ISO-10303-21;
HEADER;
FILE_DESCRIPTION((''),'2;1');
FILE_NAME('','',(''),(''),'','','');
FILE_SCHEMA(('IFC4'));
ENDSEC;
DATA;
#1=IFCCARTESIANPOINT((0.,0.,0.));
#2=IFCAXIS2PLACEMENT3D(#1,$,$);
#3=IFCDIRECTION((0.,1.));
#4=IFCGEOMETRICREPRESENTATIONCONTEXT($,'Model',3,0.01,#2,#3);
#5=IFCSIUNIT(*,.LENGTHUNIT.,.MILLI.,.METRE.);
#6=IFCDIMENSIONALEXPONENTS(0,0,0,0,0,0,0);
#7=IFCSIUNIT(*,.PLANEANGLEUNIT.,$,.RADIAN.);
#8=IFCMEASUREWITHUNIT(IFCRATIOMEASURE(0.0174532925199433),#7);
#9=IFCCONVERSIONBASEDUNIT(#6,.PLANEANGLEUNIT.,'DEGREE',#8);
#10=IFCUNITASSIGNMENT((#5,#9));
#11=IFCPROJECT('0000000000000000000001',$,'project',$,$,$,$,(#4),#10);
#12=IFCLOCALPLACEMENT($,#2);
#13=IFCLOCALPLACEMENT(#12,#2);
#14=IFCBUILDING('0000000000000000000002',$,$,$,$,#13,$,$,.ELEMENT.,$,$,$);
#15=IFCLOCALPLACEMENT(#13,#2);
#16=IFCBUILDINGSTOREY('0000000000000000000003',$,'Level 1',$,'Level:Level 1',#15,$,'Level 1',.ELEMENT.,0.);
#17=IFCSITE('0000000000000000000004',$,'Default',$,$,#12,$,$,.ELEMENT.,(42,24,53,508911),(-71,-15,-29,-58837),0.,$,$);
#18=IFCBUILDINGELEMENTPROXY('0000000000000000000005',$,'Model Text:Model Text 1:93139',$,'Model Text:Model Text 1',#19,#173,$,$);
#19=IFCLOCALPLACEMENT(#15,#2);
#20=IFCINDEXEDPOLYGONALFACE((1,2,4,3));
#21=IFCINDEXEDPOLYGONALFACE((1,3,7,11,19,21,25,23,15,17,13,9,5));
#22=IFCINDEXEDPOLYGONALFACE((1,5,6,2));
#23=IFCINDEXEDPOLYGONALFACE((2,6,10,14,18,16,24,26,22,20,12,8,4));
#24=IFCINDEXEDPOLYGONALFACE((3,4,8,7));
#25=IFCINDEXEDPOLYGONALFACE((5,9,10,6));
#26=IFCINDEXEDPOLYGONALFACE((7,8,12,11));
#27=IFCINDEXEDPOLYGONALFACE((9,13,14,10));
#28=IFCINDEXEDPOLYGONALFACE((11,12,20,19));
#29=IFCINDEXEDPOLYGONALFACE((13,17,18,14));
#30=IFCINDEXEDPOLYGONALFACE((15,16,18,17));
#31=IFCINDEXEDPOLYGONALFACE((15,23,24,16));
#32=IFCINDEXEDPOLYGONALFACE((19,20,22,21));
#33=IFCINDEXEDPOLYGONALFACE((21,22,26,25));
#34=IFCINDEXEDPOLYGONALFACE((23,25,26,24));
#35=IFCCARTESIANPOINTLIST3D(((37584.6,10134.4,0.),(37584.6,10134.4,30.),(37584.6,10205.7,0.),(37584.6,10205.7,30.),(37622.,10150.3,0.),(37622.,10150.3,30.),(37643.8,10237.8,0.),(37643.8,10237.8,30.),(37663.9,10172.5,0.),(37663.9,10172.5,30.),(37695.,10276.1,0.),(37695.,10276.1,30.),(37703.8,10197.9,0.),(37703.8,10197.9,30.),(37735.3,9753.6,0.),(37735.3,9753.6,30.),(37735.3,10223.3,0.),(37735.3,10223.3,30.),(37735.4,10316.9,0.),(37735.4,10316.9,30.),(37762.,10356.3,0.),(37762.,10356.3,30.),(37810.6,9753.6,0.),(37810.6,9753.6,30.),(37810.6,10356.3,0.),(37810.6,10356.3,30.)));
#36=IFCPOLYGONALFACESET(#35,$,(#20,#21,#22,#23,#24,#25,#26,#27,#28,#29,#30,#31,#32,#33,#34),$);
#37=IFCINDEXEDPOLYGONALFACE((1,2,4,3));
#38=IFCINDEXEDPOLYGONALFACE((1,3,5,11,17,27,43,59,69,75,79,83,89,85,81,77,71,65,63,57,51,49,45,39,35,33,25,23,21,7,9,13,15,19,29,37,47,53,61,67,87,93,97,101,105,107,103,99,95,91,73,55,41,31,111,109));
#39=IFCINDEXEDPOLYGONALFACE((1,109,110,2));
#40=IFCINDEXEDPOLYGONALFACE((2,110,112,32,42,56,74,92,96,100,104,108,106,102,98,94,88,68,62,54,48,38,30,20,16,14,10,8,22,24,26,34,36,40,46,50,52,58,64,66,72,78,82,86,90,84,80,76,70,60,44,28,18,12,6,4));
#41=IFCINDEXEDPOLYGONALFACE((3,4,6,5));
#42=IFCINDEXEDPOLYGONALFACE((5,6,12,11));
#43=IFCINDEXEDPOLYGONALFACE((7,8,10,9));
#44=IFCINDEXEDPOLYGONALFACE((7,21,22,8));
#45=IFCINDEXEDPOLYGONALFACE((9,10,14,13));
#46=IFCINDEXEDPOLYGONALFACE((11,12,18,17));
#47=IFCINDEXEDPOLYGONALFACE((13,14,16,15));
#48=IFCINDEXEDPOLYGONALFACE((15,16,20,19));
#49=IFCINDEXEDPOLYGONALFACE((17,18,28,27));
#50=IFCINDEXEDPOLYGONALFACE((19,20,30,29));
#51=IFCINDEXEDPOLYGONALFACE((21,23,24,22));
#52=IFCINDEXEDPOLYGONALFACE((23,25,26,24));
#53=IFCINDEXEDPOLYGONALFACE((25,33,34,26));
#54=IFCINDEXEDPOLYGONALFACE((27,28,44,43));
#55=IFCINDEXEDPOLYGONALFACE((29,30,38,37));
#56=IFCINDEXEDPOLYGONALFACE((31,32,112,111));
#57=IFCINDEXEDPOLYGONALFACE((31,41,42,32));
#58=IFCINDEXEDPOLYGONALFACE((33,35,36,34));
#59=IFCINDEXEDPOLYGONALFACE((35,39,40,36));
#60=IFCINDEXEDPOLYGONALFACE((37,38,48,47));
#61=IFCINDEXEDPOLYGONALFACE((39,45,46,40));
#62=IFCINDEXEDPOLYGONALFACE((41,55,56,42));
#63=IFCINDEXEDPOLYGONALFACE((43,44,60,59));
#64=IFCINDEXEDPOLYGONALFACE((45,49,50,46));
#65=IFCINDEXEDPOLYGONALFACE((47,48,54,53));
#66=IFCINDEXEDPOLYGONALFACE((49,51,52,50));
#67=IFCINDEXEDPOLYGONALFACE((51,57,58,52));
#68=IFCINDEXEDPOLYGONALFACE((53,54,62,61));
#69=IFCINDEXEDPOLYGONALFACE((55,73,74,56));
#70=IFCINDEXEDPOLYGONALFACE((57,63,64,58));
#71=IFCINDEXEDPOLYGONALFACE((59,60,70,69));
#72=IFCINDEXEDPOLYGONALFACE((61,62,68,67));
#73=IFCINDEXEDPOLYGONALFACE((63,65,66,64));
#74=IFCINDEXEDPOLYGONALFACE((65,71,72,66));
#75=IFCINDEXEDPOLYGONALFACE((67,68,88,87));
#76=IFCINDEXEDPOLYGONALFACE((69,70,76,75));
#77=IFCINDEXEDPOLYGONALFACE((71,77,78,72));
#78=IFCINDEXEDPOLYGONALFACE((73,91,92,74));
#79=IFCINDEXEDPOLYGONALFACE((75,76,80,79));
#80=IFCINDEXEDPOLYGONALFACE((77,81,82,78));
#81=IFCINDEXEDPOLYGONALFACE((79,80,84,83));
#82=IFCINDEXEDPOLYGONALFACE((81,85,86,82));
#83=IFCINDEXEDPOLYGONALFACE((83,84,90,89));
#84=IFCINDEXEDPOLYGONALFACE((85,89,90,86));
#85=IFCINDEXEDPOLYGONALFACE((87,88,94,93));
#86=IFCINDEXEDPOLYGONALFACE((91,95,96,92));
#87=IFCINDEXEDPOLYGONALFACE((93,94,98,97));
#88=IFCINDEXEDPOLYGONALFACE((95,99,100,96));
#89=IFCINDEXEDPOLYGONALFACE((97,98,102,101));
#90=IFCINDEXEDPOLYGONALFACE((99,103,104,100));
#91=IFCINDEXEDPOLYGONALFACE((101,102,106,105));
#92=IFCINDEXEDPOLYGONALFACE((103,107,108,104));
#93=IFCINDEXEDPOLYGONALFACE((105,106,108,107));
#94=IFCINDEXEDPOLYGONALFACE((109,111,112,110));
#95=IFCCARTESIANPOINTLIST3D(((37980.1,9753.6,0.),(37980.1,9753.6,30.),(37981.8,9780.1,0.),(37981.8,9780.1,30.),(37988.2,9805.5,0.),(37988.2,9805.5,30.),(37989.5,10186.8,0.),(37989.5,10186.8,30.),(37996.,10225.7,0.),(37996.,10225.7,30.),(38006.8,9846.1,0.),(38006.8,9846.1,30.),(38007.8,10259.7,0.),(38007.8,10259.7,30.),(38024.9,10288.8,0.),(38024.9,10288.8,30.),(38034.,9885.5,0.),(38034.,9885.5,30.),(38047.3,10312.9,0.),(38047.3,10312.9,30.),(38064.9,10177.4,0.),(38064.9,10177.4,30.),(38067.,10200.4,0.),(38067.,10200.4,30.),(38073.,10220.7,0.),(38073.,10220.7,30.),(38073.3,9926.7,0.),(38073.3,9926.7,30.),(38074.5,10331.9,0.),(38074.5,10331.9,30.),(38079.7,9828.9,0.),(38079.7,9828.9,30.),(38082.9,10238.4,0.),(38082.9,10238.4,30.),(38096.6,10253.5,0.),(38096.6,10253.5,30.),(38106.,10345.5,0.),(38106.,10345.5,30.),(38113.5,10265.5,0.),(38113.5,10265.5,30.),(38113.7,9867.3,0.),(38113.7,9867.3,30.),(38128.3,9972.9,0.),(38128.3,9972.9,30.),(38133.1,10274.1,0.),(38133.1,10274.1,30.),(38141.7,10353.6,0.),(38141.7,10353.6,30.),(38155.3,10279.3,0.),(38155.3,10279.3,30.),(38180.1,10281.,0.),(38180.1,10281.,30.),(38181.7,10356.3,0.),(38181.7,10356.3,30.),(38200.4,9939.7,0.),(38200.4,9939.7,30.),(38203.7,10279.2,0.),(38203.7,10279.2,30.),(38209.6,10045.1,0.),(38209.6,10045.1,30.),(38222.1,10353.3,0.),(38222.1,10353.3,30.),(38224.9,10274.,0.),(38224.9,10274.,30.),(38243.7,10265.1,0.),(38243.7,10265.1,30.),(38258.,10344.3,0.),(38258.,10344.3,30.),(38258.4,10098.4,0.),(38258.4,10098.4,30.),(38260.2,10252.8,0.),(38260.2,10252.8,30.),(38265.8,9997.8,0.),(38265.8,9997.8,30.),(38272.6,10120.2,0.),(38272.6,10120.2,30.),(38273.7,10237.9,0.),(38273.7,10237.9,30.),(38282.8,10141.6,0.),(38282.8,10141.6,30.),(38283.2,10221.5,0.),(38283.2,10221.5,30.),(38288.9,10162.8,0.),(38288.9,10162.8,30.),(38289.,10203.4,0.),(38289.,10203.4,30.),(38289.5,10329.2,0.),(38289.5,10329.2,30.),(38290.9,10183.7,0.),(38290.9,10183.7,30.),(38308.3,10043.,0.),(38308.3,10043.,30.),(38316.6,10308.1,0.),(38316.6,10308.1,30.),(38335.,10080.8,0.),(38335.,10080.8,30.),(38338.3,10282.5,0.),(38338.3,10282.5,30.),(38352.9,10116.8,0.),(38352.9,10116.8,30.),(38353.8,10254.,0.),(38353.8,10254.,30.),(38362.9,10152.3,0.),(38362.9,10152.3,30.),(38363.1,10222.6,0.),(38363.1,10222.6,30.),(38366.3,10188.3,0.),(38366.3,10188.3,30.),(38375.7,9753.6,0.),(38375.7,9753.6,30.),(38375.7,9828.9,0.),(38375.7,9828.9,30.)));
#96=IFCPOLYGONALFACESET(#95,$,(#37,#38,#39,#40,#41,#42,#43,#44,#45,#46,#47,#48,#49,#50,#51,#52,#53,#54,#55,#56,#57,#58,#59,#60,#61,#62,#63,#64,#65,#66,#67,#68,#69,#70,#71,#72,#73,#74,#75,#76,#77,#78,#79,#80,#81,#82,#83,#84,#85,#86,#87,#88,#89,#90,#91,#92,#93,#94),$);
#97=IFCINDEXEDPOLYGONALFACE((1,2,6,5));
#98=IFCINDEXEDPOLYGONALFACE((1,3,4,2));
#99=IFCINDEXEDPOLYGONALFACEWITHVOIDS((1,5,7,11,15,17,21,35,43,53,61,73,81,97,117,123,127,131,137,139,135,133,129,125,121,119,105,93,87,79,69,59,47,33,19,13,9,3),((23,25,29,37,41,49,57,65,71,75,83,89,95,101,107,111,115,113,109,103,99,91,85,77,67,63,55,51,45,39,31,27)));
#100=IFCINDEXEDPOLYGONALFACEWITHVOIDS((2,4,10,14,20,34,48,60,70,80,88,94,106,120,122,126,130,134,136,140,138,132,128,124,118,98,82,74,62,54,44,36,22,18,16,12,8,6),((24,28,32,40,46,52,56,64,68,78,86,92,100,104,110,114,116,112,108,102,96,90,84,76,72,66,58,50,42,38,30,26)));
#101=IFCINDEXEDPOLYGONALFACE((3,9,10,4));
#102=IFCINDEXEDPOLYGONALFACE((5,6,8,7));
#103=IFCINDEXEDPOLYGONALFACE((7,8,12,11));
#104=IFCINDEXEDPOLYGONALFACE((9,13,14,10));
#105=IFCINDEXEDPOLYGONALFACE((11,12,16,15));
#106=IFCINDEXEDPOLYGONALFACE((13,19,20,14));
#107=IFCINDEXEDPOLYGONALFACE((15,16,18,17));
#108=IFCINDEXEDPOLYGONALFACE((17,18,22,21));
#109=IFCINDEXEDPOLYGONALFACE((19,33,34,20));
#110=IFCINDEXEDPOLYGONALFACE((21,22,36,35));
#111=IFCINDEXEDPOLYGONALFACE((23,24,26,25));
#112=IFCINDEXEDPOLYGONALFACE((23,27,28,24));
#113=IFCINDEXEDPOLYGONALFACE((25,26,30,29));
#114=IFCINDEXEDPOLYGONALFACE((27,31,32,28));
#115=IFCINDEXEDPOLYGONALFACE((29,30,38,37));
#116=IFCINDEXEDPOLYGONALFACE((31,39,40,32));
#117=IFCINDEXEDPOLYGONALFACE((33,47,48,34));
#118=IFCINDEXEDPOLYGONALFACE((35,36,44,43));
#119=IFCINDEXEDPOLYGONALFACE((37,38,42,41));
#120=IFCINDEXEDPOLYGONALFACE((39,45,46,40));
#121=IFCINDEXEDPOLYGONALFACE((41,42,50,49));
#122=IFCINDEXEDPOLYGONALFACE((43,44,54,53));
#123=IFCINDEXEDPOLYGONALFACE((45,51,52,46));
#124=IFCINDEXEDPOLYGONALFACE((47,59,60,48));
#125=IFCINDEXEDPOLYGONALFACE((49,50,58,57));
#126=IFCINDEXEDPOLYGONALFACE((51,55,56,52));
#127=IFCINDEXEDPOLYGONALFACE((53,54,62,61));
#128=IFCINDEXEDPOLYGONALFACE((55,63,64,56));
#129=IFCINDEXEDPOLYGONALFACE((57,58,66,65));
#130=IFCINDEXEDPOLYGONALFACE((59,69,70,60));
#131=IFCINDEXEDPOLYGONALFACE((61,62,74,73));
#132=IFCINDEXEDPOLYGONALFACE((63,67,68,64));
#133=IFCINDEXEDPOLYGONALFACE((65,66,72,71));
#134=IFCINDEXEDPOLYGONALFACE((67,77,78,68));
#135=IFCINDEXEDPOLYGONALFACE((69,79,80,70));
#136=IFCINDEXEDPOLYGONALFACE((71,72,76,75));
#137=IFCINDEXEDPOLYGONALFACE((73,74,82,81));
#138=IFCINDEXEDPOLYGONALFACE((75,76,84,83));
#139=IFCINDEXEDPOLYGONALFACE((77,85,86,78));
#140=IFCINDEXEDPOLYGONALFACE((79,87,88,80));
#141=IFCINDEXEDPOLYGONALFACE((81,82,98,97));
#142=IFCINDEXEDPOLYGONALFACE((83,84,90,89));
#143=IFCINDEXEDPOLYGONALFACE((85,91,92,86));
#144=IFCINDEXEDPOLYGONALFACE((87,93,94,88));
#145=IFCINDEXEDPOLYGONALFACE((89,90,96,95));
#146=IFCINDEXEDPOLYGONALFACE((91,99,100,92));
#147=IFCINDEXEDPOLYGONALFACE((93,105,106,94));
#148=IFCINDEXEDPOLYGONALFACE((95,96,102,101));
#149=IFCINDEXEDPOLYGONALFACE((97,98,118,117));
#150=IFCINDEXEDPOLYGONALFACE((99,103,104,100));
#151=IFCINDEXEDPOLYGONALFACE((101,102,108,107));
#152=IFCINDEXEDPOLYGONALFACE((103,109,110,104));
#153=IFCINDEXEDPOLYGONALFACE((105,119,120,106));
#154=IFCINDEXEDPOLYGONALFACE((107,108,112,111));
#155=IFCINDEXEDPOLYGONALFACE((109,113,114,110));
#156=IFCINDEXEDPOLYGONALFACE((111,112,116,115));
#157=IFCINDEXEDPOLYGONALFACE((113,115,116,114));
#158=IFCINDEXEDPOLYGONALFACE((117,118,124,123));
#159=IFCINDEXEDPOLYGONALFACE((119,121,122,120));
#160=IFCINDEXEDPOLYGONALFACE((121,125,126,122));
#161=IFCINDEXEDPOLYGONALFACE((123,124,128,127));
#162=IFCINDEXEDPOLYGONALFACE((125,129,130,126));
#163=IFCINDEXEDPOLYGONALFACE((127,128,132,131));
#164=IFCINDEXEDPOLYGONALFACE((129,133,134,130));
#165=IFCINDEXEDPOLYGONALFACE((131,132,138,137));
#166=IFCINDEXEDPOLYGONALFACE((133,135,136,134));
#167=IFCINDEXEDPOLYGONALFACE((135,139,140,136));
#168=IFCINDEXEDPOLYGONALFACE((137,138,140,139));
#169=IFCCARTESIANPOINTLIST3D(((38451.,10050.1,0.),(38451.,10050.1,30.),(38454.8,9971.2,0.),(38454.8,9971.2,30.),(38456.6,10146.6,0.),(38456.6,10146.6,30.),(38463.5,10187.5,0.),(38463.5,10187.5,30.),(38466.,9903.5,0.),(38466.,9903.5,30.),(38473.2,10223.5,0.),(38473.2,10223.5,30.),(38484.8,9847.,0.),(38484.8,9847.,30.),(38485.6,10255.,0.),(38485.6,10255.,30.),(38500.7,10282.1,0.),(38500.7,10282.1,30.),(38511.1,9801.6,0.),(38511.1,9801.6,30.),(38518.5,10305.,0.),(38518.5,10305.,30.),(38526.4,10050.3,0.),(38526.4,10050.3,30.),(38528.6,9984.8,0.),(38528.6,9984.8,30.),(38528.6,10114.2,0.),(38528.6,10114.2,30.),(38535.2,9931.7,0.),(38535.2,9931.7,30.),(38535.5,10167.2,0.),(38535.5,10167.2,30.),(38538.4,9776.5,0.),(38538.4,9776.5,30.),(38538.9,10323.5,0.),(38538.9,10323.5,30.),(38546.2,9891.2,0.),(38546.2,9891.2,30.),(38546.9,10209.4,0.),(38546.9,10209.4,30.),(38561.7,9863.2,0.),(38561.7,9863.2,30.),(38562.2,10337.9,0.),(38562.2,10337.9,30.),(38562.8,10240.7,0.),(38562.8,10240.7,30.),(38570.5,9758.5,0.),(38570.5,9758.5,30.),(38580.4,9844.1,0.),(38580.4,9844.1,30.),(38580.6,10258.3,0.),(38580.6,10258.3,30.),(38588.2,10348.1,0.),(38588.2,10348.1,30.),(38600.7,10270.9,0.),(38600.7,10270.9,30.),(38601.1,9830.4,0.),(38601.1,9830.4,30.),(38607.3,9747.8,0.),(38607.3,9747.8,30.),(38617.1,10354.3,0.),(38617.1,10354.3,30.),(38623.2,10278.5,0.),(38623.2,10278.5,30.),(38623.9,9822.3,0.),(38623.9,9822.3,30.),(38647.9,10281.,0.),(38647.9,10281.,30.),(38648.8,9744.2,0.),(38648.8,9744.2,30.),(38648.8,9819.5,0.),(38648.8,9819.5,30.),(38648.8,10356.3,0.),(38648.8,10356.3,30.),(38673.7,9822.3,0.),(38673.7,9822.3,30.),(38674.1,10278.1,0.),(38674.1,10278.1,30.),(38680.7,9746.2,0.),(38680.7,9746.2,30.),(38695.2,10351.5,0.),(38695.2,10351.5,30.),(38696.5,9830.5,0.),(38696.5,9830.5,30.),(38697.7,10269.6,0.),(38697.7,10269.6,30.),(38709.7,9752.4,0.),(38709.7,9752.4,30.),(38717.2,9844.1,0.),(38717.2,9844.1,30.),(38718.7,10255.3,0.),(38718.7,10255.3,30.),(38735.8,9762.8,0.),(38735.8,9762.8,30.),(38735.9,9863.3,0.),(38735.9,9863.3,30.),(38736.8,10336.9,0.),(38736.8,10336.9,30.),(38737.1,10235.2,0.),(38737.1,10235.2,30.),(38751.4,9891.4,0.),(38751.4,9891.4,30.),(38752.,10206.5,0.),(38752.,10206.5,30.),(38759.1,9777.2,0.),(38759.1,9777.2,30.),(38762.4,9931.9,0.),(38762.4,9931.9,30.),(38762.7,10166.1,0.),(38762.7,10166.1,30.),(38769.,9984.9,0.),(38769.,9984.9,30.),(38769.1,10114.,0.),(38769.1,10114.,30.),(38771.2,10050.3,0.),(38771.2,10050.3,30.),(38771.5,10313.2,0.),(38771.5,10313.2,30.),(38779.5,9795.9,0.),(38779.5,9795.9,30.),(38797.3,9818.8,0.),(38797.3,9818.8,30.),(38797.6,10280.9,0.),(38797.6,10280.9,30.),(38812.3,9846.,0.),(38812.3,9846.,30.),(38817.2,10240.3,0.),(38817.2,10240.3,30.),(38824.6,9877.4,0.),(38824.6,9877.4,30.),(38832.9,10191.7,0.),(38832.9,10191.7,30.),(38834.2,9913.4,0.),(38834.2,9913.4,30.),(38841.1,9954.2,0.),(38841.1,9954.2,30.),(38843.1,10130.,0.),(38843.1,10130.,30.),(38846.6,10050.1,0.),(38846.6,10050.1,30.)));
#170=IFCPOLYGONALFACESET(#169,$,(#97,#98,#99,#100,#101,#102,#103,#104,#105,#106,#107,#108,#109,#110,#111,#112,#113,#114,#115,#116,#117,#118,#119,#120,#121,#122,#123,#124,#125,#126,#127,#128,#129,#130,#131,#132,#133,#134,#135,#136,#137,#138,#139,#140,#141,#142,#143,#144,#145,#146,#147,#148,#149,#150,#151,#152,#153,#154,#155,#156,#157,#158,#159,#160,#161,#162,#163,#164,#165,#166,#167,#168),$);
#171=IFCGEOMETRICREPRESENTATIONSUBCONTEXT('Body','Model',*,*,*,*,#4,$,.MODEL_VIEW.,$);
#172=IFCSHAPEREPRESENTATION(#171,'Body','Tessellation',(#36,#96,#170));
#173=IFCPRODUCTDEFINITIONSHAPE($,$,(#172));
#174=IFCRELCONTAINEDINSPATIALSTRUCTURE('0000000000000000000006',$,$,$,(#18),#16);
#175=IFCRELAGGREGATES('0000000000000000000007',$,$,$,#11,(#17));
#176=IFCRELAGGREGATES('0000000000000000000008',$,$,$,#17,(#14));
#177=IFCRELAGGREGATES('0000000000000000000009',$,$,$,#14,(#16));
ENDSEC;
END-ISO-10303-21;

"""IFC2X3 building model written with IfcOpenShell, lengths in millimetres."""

from ifc_helpers import new_model, entity, si_unit, converted_unit, direction, frame, origin, place, context, subcontext, project, spatial, polyline, outline, extrude, element, save


model = new_model("IFC2X3")

# Units and contexts
model_context = context("Model", 3, precision=0.01, world=origin(), true_north=direction((0.0, 1.0)))
body_context = subcontext(model_context, "Body", "Model", "MODEL_VIEW")
ifc_project = project(units=[si_unit("LENGTHUNIT", "METRE", prefix="MILLI"), converted_unit("PLANEANGLEUNIT", "DEGREE", entity("IfcRatioMeasure", 0.0174532925199433), si_unit("PLANEANGLEUNIT", "RADIAN"), dimensions=[0, 0, 0, 0, 0, 0, 0])], contexts=[model_context])

# Site, building, storey
site_placement = place(None, origin())
site = spatial("IfcSite", under=ifc_project, at=site_placement, Name="Default", CompositionType="ELEMENT", RefLatitude=(42, 24, 53, 508911), RefLongitude=(-71, -15, -29, -58837), RefElevation=0.0)
building_placement = place(site_placement, origin())
building = spatial("IfcBuilding", under=site, at=building_placement, CompositionType="ELEMENT")
storey_placement = place(building_placement, origin())
storey = spatial("IfcBuildingStorey", under=building, at=storey_placement, Name="Level 1", ObjectType="Level:Level 1", LongName="Level 1", CompositionType="ELEMENT", Elevation=0.0)

# Building element proxy
proxy_1_placement = place(storey_placement, origin())
element("IfcBuildingElementProxy", 1, at=proxy_1_placement, inside=storey, Name="Model Text:Model Text 1:93139", ObjectType="Model Text:Model Text 1", context=body_context, shape_type="SweptSolid", body=[
    extrude(outline(polyline([(-410.6, -111.6), (192.1, -111.6), (192.1, -63.1), (152.7, -36.4), (111.9, 4.0), (73.6, 55.2), (41.4, 114.4), (-29.8, 114.4), (-13.9, 77.0), (8.3, 35.1), (33.7, -4.8), (59.1, -36.3), (-410.6, -36.3), (-410.6, -111.6)])), frame((37699.0, 10164.2, 0.0), z_axis=(0.0, 0.0, 1.0), x_axis=(0.0, 1.0, 0.0)), (0.0, 0.0, 1.0), 30.0),
    extrude(outline(polyline([(-190.2, -317.5), (-190.2, -392.8), (205.4, -392.8), (203.7, -366.3), (197.3, -340.9), (178.7, -300.3), (151.5, -260.9), (112.2, -219.7), (57.2, -173.6), (-24.1, -101.3), (-72.9, -48.0), (-87.1, -26.3), (-97.3, -4.8), (-103.4, 16.4), (-105.4, 37.3), (-103.5, 57.0), (-97.7, 75.0), (-88.2, 91.5), (-74.7, 106.4), (-58.2, 118.7), (-39.4, 127.5), (-18.2, 132.8), (5.4, 134.6), (30.2, 132.9), (52.4, 127.7), (72.0, 119.1), (88.9, 107.1), (102.6, 92.0), (112.5, 74.3), (118.5, 54.0), (120.6, 31.0), (196.0, 40.4), (189.5, 79.3), (177.7, 113.3), (160.6, 142.4), (138.2, 166.5), (111.0, 185.5), (79.5, 199.1), (43.8, 207.2), (3.8, 209.9), (-36.6, 206.9), (-72.5, 197.9), (-104.0, 182.8), (-131.1, 161.7), (-152.8, 136.1), (-168.3, 107.6), (-177.6, 76.2), (-180.8, 41.9), (-177.4, 5.8), (-167.4, -29.6), (-149.5, -65.6), (-122.8, -103.4), (-80.3, -148.6), (-14.9, -206.7), (71.8, -279.1), (105.8, -317.5), (-190.2, -317.5)])), frame((38185.5, 10146.4, 0.0), z_axis=(0.0, 0.0, -1.0), x_axis=(-1.0, 0.0, 0.0)), (0.0, 0.0, -1.0), 30.0),
    extrude(outline(polyline([(-10.6, -198.7), (68.3, -198.7), (136.5, -190.7), (193.9, -174.7), (240.5, -150.6), (266.9, -124.4), (286.3, -93.2), (298.8, -57.0), (304.3, -15.7), (303.8, 16.2), (299.0, 45.5), (289.9, 72.1), (276.6, 96.0), (258.9, 117.3), (236.9, 136.2), (210.4, 152.5), (179.6, 166.3), (144.1, 177.6), (103.7, 186.3), (8.2, 196.4), (-71.8, 196.7), (-134.0, 189.4), (-183.3, 176.1), (-224.7, 158.4), (-258.2, 133.9), (-283.5, 100.3), (-300.1, 59.5), (-307.1, 13.4), (-306.6, -18.4), (-301.8, -47.5), (-292.8, -74.0), (-279.6, -97.9), (-262.0, -119.2), (-240.0, -138.1), (-213.6, -154.5), (-182.8, -168.4), (-147.3, -179.8), (-106.7, -188.6), (-10.6, -198.7)]), holes=[polyline([(-7.2, -123.5), (-71.0, -118.2), (-123.6, -108.8), (-165.2, -95.4), (-195.7, -78.0), (-212.4, -59.4), (-224.1, -38.7), (-230.6, -15.9), (-231.9, 8.9), (-227.8, 35.0), (-218.1, 58.1), (-202.8, 78.4), (-182.0, 95.8), (-152.6, 109.4), (-111.7, 118.1), (-59.4, 122.0), (4.4, 121.1), (69.6, 115.8), (122.2, 106.7), (162.2, 93.7), (189.5, 77.0), (207.7, 57.4), (220.4, 36.0), (227.5, 12.8), (229.1, -12.1), (225.2, -36.8), (215.9, -59.2), (201.3, -79.3), (181.4, -97.1), (152.6, -111.2), (111.6, -120.3), (58.3, -124.4), (-7.2, -123.5)])]), frame((38650.0, 10048.9, 0.0), z_axis=(0.0, 0.0, 1.0), x_axis=(0.047515, -0.998871, 0.0)), (0.0, 0.0, 1.0), 30.0),
])

save(model, "model.ifc")
